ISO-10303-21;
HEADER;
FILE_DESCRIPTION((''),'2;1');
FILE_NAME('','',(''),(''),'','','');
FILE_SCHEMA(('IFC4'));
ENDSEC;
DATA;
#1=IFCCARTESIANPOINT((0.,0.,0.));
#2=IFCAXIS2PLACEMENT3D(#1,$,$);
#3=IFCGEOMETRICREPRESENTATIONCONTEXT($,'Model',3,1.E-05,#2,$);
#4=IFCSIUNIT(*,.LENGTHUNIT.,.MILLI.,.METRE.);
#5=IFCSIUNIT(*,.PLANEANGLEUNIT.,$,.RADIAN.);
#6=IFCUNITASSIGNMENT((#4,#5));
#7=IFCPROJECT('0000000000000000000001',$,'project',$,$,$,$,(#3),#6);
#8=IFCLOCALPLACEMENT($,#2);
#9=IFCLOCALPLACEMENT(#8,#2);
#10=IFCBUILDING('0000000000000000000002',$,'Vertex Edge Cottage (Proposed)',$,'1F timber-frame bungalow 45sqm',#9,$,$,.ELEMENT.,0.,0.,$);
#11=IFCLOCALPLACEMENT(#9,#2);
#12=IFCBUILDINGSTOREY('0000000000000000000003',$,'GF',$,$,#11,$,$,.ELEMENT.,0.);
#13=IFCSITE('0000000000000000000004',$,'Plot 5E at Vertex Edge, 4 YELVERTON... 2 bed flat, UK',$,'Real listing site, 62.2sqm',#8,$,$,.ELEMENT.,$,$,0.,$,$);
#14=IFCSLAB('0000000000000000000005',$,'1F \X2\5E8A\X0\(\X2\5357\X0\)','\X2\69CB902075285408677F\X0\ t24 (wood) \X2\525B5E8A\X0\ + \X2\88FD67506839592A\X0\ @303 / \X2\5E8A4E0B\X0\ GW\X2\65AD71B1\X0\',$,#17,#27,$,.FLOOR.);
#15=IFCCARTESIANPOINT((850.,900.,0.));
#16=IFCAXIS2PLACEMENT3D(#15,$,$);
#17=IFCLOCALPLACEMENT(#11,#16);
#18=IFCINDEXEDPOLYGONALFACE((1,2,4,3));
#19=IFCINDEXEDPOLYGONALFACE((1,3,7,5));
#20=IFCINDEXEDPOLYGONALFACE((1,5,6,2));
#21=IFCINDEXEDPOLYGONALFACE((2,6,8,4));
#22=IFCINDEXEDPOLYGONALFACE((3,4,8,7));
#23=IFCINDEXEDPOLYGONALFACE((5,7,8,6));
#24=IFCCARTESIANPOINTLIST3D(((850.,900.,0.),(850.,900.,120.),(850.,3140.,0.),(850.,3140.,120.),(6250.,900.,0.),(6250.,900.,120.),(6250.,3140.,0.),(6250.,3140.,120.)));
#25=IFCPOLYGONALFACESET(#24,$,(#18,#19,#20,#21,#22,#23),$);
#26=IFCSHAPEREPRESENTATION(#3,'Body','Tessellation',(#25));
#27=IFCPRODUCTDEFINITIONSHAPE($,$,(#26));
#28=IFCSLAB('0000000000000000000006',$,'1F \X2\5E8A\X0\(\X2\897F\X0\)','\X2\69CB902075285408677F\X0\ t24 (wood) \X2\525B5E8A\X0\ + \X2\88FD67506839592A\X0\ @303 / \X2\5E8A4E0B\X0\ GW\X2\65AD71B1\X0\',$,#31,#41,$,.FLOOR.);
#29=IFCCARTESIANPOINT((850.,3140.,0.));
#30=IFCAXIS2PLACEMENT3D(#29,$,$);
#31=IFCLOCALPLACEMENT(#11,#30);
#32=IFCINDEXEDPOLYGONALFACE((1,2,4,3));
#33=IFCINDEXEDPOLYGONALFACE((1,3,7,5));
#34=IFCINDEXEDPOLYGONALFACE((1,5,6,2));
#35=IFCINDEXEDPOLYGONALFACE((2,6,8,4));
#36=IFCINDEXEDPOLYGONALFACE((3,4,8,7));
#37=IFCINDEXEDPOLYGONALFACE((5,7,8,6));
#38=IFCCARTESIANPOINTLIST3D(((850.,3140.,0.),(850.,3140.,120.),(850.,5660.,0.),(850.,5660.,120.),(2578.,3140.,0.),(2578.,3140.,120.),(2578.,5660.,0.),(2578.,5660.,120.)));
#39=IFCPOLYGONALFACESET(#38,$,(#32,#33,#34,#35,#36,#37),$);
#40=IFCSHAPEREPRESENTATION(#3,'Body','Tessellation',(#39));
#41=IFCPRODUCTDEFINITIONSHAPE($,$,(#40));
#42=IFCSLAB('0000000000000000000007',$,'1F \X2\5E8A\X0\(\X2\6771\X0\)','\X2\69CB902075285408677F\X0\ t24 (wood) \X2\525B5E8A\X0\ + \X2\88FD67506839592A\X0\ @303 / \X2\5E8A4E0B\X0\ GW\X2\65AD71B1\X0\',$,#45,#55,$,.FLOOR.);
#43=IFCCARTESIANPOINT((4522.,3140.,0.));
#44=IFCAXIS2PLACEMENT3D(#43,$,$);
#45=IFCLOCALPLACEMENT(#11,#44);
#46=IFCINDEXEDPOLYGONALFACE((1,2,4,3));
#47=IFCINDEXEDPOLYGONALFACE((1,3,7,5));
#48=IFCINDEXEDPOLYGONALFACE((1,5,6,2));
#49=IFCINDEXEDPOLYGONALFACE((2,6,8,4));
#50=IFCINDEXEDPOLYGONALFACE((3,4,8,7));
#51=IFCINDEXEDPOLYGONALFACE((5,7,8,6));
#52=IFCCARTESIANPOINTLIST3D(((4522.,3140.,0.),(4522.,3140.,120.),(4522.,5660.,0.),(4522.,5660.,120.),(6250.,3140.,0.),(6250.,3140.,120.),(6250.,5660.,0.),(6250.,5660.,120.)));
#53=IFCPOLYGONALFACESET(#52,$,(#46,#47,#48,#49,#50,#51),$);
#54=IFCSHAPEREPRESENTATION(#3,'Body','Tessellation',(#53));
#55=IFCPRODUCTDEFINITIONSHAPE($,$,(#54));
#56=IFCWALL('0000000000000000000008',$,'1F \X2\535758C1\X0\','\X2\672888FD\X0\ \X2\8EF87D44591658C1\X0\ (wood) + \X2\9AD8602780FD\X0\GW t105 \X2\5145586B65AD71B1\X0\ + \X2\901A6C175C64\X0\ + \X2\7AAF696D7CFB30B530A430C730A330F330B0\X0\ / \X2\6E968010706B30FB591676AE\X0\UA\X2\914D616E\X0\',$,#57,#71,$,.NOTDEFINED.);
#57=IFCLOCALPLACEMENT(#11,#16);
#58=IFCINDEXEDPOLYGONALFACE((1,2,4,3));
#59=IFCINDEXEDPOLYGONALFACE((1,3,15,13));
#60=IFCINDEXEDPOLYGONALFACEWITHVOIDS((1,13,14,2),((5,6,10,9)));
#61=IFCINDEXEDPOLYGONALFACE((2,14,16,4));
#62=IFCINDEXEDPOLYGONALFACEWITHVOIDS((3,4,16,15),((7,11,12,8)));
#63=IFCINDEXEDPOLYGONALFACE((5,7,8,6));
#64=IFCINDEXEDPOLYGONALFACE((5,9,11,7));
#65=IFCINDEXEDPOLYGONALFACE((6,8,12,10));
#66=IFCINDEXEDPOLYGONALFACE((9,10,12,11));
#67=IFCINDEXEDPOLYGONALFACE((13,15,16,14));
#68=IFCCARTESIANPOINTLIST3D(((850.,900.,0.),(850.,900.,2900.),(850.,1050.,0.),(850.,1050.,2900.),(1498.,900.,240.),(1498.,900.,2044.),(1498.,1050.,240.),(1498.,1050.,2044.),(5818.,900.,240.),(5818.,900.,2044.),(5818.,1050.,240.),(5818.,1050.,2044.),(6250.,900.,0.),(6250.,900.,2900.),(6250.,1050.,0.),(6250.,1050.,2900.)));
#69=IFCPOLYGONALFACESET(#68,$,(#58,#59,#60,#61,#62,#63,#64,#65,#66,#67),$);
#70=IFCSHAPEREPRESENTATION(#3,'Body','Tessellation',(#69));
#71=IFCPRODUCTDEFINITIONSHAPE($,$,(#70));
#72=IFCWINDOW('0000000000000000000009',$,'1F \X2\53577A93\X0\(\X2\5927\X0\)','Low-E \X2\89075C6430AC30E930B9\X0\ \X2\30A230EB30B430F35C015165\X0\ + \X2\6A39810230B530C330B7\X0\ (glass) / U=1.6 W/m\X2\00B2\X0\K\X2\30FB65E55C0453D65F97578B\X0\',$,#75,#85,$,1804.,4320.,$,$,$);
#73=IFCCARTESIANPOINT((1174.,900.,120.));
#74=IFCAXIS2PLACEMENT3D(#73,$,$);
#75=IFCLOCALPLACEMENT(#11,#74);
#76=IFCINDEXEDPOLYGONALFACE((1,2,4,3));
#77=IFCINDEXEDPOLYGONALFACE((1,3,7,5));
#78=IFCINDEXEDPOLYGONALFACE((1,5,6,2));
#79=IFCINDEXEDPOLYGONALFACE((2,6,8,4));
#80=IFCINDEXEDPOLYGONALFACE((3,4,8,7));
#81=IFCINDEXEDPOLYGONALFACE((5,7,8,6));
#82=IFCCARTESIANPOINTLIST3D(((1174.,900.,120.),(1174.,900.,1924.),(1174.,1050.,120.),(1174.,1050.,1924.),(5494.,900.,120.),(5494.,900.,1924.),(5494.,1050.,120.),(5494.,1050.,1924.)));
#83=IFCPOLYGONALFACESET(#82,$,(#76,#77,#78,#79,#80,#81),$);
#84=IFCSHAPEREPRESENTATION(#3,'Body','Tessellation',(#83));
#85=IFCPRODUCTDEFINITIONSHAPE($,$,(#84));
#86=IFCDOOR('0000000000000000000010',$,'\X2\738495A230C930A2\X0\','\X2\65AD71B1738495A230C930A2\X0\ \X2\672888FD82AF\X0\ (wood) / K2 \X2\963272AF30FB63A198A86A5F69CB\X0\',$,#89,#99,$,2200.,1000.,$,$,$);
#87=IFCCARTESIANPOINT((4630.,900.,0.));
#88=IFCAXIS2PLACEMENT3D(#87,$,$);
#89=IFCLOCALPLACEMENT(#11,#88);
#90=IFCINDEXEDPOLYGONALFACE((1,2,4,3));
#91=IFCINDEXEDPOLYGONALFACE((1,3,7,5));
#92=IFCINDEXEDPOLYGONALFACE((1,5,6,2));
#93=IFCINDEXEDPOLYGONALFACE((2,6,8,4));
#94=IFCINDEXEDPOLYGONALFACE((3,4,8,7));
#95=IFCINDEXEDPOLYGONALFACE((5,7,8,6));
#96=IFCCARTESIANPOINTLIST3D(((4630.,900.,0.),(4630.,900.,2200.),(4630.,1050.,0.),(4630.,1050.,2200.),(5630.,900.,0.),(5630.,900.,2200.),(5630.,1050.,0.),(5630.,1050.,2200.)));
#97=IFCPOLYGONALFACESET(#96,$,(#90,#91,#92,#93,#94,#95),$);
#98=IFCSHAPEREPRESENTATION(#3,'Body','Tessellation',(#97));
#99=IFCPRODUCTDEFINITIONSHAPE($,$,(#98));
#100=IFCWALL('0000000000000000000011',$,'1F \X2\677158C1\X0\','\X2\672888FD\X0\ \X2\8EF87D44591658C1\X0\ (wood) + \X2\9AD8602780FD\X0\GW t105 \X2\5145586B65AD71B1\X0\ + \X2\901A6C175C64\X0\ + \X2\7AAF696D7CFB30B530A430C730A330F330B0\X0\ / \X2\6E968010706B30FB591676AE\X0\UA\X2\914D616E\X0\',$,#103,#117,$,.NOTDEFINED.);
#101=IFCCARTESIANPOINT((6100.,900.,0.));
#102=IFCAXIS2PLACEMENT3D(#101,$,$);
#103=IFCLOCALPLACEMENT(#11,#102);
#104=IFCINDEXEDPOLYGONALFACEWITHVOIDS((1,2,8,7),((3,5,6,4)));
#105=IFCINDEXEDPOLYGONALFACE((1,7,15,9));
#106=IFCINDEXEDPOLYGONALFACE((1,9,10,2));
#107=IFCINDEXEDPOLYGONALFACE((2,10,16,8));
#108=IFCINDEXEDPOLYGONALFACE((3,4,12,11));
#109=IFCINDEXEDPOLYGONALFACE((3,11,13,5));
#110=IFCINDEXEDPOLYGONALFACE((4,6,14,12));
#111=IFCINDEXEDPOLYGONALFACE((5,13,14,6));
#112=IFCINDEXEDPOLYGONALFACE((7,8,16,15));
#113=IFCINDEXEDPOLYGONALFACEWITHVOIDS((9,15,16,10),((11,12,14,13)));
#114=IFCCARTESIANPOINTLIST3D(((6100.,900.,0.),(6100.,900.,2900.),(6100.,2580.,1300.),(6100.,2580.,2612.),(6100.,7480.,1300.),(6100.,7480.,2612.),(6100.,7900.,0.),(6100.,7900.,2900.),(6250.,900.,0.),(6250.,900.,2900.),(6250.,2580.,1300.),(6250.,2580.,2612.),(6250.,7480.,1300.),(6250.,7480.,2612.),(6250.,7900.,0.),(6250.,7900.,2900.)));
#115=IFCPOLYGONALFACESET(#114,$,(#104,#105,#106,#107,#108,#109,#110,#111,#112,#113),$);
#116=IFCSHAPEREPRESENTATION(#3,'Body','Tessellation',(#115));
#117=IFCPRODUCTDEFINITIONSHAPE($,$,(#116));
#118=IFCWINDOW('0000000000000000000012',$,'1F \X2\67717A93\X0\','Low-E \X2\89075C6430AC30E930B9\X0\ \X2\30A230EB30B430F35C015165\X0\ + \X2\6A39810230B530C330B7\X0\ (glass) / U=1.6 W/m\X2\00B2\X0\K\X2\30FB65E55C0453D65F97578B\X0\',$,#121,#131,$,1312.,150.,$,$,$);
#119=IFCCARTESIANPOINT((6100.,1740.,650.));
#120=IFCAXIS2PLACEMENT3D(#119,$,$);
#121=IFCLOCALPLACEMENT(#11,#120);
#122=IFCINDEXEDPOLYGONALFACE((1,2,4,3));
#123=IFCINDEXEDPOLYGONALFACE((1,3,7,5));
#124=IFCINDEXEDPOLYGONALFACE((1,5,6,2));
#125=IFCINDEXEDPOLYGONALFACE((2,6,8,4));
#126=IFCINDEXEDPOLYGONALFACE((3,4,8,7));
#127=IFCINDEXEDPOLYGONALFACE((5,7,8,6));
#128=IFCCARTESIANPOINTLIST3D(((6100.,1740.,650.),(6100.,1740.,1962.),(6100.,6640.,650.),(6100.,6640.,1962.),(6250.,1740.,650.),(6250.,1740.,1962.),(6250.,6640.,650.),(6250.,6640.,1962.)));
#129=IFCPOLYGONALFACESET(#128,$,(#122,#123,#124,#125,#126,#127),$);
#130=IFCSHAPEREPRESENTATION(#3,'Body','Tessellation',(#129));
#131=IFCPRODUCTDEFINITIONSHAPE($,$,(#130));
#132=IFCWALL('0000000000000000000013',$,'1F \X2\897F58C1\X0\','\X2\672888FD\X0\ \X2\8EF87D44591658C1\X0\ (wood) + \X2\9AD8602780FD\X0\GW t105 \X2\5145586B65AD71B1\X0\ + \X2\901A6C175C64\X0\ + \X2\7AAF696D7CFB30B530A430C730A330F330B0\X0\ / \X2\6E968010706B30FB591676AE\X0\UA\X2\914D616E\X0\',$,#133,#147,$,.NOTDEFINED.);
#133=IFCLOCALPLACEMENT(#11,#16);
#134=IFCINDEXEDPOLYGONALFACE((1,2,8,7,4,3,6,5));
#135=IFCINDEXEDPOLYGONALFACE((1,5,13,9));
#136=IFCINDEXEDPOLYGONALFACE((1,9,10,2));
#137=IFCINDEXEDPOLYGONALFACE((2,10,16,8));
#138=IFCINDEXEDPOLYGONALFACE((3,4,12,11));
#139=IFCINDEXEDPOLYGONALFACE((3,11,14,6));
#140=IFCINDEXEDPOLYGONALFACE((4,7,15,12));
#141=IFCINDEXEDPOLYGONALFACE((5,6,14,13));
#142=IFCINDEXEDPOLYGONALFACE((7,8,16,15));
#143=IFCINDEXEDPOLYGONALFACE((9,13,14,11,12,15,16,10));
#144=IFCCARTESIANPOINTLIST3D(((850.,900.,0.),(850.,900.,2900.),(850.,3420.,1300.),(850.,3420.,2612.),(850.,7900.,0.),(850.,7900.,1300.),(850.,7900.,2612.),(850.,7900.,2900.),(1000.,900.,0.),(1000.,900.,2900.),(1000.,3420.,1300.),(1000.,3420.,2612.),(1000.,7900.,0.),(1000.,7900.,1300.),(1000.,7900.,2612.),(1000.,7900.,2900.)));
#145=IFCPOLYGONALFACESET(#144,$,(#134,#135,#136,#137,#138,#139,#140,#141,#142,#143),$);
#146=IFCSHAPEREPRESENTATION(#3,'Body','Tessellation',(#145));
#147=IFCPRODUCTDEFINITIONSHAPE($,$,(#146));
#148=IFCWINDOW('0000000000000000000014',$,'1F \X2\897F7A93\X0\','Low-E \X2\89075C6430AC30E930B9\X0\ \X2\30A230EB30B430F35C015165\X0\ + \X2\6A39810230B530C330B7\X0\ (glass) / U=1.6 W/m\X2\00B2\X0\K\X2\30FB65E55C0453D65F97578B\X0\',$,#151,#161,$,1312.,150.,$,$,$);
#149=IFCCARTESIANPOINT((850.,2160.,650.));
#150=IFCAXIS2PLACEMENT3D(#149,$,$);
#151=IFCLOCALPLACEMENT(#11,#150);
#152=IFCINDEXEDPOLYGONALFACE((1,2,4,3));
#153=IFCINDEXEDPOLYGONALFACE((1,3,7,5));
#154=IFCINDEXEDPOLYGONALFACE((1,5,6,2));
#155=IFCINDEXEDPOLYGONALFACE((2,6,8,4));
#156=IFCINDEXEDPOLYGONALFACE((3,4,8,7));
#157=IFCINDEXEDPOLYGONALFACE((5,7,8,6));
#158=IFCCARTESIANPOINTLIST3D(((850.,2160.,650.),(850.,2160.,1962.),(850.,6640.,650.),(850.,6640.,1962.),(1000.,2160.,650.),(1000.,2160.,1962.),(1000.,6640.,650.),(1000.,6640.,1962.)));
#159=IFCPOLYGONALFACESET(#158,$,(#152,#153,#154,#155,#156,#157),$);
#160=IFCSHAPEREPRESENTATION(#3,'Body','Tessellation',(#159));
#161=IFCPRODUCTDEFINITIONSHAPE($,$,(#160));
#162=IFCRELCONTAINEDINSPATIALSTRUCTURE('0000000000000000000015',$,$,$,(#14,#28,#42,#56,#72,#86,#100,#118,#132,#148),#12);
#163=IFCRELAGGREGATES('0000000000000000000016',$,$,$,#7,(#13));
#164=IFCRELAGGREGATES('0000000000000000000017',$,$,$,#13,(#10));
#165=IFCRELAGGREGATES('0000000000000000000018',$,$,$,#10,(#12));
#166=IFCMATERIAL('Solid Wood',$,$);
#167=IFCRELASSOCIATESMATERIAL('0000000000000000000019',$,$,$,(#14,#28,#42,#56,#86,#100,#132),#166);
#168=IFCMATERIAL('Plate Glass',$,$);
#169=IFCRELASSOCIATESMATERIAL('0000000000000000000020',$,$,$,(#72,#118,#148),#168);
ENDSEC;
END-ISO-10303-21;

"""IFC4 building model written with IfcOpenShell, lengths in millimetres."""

from ifc_helpers import new_model, si_unit, frame, frame_2d, origin, place, context, project, spatial, rectangle, extrude, material, element, fill, save


model = new_model("IFC4")

# Units and contexts
model_context = context("Model", 3, precision=1e-05, world=origin())
ifc_project = project(units=[si_unit("LENGTHUNIT", "METRE", prefix="MILLI"), si_unit("PLANEANGLEUNIT", "RADIAN")], contexts=[model_context])

# Site, building, storey
site_placement = place(None, origin())
site = spatial("IfcSite", under=ifc_project, at=site_placement, Name="Plot 5E at Vertex Edge, 4 YELVERTON... 2 bed flat, UK", ObjectType="Real listing site, 62.2sqm", CompositionType="ELEMENT", RefElevation=0.0)
building_placement = place(site_placement, origin())
building = spatial("IfcBuilding", under=site, at=building_placement, Name="Vertex Edge Cottage (Proposed)", ObjectType="1F timber-frame bungalow 45sqm", CompositionType="ELEMENT", ElevationOfRefHeight=0.0, ElevationOfTerrain=0.0)
storey_placement = place(building_placement, origin())
storey = spatial("IfcBuildingStorey", under=building, at=storey_placement, Name="GF", CompositionType="ELEMENT", Elevation=0.0)

# Slabs
ifc_material_1 = material(Name="Solid Wood")
slab_1_placement = place(storey_placement, frame((850.0, 900.0, 0.0)))
element("IfcSlab", 1, at=slab_1_placement, inside=storey, material=ifc_material_1, Name="1F 床(南)", Description="構造用合板 t24 (wood) 剛床 + 製材根太 @303 / 床下 GW断熱", PredefinedType="FLOOR", context=model_context, shape_type="SweptSolid", body=[
    extrude(rectangle(XDim=5400.0, YDim=2240.0, at=frame_2d((2700.0, 1120.0))), frame((850.0, 900.0, 0.0)), (0.0, 0.0, 1.0), 120.0),
])
slab_2_placement = place(storey_placement, frame((850.0, 3140.0, 0.0)))
element("IfcSlab", 2, at=slab_2_placement, inside=storey, material=ifc_material_1, Name="1F 床(西)", Description="構造用合板 t24 (wood) 剛床 + 製材根太 @303 / 床下 GW断熱", PredefinedType="FLOOR", context=model_context, shape_type="SweptSolid", body=[
    extrude(rectangle(XDim=1728.0, YDim=2520.0, at=frame_2d((864.0, 1260.0))), frame((850.0, 3140.0, 0.0)), (0.0, 0.0, 1.0), 120.0),
])
slab_3_placement = place(storey_placement, frame((4522.0, 3140.0, 0.0)))
element("IfcSlab", 3, at=slab_3_placement, inside=storey, material=ifc_material_1, Name="1F 床(東)", Description="構造用合板 t24 (wood) 剛床 + 製材根太 @303 / 床下 GW断熱", PredefinedType="FLOOR", context=model_context, shape_type="SweptSolid", body=[
    extrude(rectangle(XDim=1728.0, YDim=2520.0, at=frame_2d((864.0, 1260.0))), frame((4522.0, 3140.0, 0.0)), (0.0, 0.0, 1.0), 120.0),
])

# Wall, openings, window, door
wall_1_placement = place(storey_placement, frame((850.0, 900.0, 0.0)))
wall_1 = element("IfcWall", 4, at=wall_1_placement, inside=storey, material=ifc_material_1, Name="1F 南壁", Description="木製 軸組外壁 (wood) + 高性能GW t105 充填断熱 + 通気層 + 窯業系サイディング / 準耐火・外皮UA配慮", PredefinedType="NOTDEFINED", context=model_context, shape_type="SweptSolid", body=[
    extrude(rectangle(XDim=5400.0, YDim=150.0, at=frame_2d((2700.0, 75.0))), frame((850.0, 900.0, 0.0)), (0.0, 0.0, 1.0), 2900.0),
])
opening_1_placement = place(storey_placement, frame((1174.0, 900.0, 120.0)))
opening_1 = element("IfcOpeningElement", 5, at=opening_1_placement, cuts=wall_1, PredefinedType="NOTDEFINED", context=model_context, shape_type="SweptSolid", body=[
    extrude(rectangle(XDim=4320.0, YDim=150.0, at=frame_2d((2160.0, 75.0))), frame((1174.0, 900.0, 120.0)), (0.0, 0.0, 1.0), 1804.0),
])
opening_2_placement = place(storey_placement, frame((4630.0, 900.0, 0.0)))
opening_2 = element("IfcOpeningElement", 6, at=opening_2_placement, cuts=wall_1, PredefinedType="NOTDEFINED", context=model_context, shape_type="SweptSolid", body=[
    extrude(rectangle(XDim=1000.0, YDim=150.0, at=frame_2d((500.0, 75.0))), frame((4630.0, 900.0, 0.0)), (0.0, 0.0, 1.0), 2200.0),
])
ifc_material_2 = material(Name="Plate Glass")
window_1_placement = place(storey_placement, frame((1174.0, 900.0, 120.0)))
window_1 = element("IfcWindow", 7, at=window_1_placement, inside=storey, material=ifc_material_2, Name="1F 南窓(大)", Description="Low-E 複層ガラス アルゴン封入 + 樹脂サッシ (glass) / U=1.6 W/m²K・日射取得型", OverallHeight=1804.0, OverallWidth=4320.0, context=model_context, shape_type="SweptSolid", body=[
    extrude(rectangle(XDim=4320.0, YDim=150.0, at=frame_2d((2160.0, 75.0))), frame((1174.0, 900.0, 120.0)), (0.0, 0.0, 1.0), 1804.0),
])
fill(opening_1, window_1)
door_placement = place(storey_placement, frame((4630.0, 900.0, 0.0)))
door = element("IfcDoor", 8, at=door_placement, inside=storey, material=ifc_material_1, Name="玄関ドア", Description="断熱玄関ドア 木製芯 (wood) / K2 防犯・採風機構", OverallHeight=2200.0, OverallWidth=1000.0, context=model_context, shape_type="SweptSolid", body=[
    extrude(rectangle(XDim=1000.0, YDim=150.0, at=frame_2d((500.0, 75.0))), frame((4630.0, 900.0, 0.0)), (0.0, 0.0, 1.0), 2200.0),
])
fill(opening_2, door)

# Walls, openings, windows
wall_2_placement = place(storey_placement, frame((6100.0, 900.0, 0.0)))
wall_2 = element("IfcWall", 9, at=wall_2_placement, inside=storey, material=ifc_material_1, Name="1F 東壁", Description="木製 軸組外壁 (wood) + 高性能GW t105 充填断熱 + 通気層 + 窯業系サイディング / 準耐火・外皮UA配慮", PredefinedType="NOTDEFINED", context=model_context, shape_type="SweptSolid", body=[
    extrude(rectangle(XDim=150.0, YDim=7000.0, at=frame_2d((75.0, 3500.0))), frame((6100.0, 900.0, 0.0)), (0.0, 0.0, 1.0), 2900.0),
])
opening_3_placement = place(storey_placement, frame((6100.0, 1740.0, 650.0)))
opening_3 = element("IfcOpeningElement", 10, at=opening_3_placement, cuts=wall_2, PredefinedType="NOTDEFINED", context=model_context, shape_type="SweptSolid", body=[
    extrude(rectangle(XDim=150.0, YDim=4900.0, at=frame_2d((75.0, 2450.0))), frame((6100.0, 1740.0, 650.0)), (0.0, 0.0, 1.0), 1312.0),
])
window_2_placement = place(storey_placement, frame((6100.0, 1740.0, 650.0)))
window_2 = element("IfcWindow", 11, at=window_2_placement, inside=storey, material=ifc_material_2, Name="1F 東窓", Description="Low-E 複層ガラス アルゴン封入 + 樹脂サッシ (glass) / U=1.6 W/m²K・日射取得型", OverallHeight=1312.0, OverallWidth=150.0, context=model_context, shape_type="SweptSolid", body=[
    extrude(rectangle(XDim=150.0, YDim=4900.0, at=frame_2d((75.0, 2450.0))), frame((6100.0, 1740.0, 650.0)), (0.0, 0.0, 1.0), 1312.0),
])
fill(opening_3, window_2)
wall_3_placement = place(storey_placement, frame((850.0, 900.0, 0.0)))
wall_3 = element("IfcWall", 12, at=wall_3_placement, inside=storey, material=ifc_material_1, Name="1F 西壁", Description="木製 軸組外壁 (wood) + 高性能GW t105 充填断熱 + 通気層 + 窯業系サイディング / 準耐火・外皮UA配慮", PredefinedType="NOTDEFINED", context=model_context, shape_type="SweptSolid", body=[
    extrude(rectangle(XDim=150.0, YDim=7000.0, at=frame_2d((75.0, 3500.0))), frame((850.0, 900.0, 0.0)), (0.0, 0.0, 1.0), 2900.0),
])
opening_4_placement = place(storey_placement, frame((850.0, 2160.0, 650.0)))
opening_4 = element("IfcOpeningElement", 13, at=opening_4_placement, cuts=wall_3, PredefinedType="NOTDEFINED", context=model_context, shape_type="SweptSolid", body=[
    extrude(rectangle(XDim=150.0, YDim=4480.0, at=frame_2d((75.0, 2240.0))), frame((850.0, 2160.0, 650.0)), (0.0, 0.0, 1.0), 1312.0),
])
window_3_placement = place(storey_placement, frame((850.0, 2160.0, 650.0)))
window_3 = element("IfcWindow", 14, at=window_3_placement, inside=storey, material=ifc_material_2, Name="1F 西窓", Description="Low-E 複層ガラス アルゴン封入 + 樹脂サッシ (glass) / U=1.6 W/m²K・日射取得型", OverallHeight=1312.0, OverallWidth=150.0, context=model_context, shape_type="SweptSolid", body=[
    extrude(rectangle(XDim=150.0, YDim=4480.0, at=frame_2d((75.0, 2240.0))), frame((850.0, 2160.0, 650.0)), (0.0, 0.0, 1.0), 1312.0),
])
fill(opening_4, window_3)

save(model, "model.ifc")
